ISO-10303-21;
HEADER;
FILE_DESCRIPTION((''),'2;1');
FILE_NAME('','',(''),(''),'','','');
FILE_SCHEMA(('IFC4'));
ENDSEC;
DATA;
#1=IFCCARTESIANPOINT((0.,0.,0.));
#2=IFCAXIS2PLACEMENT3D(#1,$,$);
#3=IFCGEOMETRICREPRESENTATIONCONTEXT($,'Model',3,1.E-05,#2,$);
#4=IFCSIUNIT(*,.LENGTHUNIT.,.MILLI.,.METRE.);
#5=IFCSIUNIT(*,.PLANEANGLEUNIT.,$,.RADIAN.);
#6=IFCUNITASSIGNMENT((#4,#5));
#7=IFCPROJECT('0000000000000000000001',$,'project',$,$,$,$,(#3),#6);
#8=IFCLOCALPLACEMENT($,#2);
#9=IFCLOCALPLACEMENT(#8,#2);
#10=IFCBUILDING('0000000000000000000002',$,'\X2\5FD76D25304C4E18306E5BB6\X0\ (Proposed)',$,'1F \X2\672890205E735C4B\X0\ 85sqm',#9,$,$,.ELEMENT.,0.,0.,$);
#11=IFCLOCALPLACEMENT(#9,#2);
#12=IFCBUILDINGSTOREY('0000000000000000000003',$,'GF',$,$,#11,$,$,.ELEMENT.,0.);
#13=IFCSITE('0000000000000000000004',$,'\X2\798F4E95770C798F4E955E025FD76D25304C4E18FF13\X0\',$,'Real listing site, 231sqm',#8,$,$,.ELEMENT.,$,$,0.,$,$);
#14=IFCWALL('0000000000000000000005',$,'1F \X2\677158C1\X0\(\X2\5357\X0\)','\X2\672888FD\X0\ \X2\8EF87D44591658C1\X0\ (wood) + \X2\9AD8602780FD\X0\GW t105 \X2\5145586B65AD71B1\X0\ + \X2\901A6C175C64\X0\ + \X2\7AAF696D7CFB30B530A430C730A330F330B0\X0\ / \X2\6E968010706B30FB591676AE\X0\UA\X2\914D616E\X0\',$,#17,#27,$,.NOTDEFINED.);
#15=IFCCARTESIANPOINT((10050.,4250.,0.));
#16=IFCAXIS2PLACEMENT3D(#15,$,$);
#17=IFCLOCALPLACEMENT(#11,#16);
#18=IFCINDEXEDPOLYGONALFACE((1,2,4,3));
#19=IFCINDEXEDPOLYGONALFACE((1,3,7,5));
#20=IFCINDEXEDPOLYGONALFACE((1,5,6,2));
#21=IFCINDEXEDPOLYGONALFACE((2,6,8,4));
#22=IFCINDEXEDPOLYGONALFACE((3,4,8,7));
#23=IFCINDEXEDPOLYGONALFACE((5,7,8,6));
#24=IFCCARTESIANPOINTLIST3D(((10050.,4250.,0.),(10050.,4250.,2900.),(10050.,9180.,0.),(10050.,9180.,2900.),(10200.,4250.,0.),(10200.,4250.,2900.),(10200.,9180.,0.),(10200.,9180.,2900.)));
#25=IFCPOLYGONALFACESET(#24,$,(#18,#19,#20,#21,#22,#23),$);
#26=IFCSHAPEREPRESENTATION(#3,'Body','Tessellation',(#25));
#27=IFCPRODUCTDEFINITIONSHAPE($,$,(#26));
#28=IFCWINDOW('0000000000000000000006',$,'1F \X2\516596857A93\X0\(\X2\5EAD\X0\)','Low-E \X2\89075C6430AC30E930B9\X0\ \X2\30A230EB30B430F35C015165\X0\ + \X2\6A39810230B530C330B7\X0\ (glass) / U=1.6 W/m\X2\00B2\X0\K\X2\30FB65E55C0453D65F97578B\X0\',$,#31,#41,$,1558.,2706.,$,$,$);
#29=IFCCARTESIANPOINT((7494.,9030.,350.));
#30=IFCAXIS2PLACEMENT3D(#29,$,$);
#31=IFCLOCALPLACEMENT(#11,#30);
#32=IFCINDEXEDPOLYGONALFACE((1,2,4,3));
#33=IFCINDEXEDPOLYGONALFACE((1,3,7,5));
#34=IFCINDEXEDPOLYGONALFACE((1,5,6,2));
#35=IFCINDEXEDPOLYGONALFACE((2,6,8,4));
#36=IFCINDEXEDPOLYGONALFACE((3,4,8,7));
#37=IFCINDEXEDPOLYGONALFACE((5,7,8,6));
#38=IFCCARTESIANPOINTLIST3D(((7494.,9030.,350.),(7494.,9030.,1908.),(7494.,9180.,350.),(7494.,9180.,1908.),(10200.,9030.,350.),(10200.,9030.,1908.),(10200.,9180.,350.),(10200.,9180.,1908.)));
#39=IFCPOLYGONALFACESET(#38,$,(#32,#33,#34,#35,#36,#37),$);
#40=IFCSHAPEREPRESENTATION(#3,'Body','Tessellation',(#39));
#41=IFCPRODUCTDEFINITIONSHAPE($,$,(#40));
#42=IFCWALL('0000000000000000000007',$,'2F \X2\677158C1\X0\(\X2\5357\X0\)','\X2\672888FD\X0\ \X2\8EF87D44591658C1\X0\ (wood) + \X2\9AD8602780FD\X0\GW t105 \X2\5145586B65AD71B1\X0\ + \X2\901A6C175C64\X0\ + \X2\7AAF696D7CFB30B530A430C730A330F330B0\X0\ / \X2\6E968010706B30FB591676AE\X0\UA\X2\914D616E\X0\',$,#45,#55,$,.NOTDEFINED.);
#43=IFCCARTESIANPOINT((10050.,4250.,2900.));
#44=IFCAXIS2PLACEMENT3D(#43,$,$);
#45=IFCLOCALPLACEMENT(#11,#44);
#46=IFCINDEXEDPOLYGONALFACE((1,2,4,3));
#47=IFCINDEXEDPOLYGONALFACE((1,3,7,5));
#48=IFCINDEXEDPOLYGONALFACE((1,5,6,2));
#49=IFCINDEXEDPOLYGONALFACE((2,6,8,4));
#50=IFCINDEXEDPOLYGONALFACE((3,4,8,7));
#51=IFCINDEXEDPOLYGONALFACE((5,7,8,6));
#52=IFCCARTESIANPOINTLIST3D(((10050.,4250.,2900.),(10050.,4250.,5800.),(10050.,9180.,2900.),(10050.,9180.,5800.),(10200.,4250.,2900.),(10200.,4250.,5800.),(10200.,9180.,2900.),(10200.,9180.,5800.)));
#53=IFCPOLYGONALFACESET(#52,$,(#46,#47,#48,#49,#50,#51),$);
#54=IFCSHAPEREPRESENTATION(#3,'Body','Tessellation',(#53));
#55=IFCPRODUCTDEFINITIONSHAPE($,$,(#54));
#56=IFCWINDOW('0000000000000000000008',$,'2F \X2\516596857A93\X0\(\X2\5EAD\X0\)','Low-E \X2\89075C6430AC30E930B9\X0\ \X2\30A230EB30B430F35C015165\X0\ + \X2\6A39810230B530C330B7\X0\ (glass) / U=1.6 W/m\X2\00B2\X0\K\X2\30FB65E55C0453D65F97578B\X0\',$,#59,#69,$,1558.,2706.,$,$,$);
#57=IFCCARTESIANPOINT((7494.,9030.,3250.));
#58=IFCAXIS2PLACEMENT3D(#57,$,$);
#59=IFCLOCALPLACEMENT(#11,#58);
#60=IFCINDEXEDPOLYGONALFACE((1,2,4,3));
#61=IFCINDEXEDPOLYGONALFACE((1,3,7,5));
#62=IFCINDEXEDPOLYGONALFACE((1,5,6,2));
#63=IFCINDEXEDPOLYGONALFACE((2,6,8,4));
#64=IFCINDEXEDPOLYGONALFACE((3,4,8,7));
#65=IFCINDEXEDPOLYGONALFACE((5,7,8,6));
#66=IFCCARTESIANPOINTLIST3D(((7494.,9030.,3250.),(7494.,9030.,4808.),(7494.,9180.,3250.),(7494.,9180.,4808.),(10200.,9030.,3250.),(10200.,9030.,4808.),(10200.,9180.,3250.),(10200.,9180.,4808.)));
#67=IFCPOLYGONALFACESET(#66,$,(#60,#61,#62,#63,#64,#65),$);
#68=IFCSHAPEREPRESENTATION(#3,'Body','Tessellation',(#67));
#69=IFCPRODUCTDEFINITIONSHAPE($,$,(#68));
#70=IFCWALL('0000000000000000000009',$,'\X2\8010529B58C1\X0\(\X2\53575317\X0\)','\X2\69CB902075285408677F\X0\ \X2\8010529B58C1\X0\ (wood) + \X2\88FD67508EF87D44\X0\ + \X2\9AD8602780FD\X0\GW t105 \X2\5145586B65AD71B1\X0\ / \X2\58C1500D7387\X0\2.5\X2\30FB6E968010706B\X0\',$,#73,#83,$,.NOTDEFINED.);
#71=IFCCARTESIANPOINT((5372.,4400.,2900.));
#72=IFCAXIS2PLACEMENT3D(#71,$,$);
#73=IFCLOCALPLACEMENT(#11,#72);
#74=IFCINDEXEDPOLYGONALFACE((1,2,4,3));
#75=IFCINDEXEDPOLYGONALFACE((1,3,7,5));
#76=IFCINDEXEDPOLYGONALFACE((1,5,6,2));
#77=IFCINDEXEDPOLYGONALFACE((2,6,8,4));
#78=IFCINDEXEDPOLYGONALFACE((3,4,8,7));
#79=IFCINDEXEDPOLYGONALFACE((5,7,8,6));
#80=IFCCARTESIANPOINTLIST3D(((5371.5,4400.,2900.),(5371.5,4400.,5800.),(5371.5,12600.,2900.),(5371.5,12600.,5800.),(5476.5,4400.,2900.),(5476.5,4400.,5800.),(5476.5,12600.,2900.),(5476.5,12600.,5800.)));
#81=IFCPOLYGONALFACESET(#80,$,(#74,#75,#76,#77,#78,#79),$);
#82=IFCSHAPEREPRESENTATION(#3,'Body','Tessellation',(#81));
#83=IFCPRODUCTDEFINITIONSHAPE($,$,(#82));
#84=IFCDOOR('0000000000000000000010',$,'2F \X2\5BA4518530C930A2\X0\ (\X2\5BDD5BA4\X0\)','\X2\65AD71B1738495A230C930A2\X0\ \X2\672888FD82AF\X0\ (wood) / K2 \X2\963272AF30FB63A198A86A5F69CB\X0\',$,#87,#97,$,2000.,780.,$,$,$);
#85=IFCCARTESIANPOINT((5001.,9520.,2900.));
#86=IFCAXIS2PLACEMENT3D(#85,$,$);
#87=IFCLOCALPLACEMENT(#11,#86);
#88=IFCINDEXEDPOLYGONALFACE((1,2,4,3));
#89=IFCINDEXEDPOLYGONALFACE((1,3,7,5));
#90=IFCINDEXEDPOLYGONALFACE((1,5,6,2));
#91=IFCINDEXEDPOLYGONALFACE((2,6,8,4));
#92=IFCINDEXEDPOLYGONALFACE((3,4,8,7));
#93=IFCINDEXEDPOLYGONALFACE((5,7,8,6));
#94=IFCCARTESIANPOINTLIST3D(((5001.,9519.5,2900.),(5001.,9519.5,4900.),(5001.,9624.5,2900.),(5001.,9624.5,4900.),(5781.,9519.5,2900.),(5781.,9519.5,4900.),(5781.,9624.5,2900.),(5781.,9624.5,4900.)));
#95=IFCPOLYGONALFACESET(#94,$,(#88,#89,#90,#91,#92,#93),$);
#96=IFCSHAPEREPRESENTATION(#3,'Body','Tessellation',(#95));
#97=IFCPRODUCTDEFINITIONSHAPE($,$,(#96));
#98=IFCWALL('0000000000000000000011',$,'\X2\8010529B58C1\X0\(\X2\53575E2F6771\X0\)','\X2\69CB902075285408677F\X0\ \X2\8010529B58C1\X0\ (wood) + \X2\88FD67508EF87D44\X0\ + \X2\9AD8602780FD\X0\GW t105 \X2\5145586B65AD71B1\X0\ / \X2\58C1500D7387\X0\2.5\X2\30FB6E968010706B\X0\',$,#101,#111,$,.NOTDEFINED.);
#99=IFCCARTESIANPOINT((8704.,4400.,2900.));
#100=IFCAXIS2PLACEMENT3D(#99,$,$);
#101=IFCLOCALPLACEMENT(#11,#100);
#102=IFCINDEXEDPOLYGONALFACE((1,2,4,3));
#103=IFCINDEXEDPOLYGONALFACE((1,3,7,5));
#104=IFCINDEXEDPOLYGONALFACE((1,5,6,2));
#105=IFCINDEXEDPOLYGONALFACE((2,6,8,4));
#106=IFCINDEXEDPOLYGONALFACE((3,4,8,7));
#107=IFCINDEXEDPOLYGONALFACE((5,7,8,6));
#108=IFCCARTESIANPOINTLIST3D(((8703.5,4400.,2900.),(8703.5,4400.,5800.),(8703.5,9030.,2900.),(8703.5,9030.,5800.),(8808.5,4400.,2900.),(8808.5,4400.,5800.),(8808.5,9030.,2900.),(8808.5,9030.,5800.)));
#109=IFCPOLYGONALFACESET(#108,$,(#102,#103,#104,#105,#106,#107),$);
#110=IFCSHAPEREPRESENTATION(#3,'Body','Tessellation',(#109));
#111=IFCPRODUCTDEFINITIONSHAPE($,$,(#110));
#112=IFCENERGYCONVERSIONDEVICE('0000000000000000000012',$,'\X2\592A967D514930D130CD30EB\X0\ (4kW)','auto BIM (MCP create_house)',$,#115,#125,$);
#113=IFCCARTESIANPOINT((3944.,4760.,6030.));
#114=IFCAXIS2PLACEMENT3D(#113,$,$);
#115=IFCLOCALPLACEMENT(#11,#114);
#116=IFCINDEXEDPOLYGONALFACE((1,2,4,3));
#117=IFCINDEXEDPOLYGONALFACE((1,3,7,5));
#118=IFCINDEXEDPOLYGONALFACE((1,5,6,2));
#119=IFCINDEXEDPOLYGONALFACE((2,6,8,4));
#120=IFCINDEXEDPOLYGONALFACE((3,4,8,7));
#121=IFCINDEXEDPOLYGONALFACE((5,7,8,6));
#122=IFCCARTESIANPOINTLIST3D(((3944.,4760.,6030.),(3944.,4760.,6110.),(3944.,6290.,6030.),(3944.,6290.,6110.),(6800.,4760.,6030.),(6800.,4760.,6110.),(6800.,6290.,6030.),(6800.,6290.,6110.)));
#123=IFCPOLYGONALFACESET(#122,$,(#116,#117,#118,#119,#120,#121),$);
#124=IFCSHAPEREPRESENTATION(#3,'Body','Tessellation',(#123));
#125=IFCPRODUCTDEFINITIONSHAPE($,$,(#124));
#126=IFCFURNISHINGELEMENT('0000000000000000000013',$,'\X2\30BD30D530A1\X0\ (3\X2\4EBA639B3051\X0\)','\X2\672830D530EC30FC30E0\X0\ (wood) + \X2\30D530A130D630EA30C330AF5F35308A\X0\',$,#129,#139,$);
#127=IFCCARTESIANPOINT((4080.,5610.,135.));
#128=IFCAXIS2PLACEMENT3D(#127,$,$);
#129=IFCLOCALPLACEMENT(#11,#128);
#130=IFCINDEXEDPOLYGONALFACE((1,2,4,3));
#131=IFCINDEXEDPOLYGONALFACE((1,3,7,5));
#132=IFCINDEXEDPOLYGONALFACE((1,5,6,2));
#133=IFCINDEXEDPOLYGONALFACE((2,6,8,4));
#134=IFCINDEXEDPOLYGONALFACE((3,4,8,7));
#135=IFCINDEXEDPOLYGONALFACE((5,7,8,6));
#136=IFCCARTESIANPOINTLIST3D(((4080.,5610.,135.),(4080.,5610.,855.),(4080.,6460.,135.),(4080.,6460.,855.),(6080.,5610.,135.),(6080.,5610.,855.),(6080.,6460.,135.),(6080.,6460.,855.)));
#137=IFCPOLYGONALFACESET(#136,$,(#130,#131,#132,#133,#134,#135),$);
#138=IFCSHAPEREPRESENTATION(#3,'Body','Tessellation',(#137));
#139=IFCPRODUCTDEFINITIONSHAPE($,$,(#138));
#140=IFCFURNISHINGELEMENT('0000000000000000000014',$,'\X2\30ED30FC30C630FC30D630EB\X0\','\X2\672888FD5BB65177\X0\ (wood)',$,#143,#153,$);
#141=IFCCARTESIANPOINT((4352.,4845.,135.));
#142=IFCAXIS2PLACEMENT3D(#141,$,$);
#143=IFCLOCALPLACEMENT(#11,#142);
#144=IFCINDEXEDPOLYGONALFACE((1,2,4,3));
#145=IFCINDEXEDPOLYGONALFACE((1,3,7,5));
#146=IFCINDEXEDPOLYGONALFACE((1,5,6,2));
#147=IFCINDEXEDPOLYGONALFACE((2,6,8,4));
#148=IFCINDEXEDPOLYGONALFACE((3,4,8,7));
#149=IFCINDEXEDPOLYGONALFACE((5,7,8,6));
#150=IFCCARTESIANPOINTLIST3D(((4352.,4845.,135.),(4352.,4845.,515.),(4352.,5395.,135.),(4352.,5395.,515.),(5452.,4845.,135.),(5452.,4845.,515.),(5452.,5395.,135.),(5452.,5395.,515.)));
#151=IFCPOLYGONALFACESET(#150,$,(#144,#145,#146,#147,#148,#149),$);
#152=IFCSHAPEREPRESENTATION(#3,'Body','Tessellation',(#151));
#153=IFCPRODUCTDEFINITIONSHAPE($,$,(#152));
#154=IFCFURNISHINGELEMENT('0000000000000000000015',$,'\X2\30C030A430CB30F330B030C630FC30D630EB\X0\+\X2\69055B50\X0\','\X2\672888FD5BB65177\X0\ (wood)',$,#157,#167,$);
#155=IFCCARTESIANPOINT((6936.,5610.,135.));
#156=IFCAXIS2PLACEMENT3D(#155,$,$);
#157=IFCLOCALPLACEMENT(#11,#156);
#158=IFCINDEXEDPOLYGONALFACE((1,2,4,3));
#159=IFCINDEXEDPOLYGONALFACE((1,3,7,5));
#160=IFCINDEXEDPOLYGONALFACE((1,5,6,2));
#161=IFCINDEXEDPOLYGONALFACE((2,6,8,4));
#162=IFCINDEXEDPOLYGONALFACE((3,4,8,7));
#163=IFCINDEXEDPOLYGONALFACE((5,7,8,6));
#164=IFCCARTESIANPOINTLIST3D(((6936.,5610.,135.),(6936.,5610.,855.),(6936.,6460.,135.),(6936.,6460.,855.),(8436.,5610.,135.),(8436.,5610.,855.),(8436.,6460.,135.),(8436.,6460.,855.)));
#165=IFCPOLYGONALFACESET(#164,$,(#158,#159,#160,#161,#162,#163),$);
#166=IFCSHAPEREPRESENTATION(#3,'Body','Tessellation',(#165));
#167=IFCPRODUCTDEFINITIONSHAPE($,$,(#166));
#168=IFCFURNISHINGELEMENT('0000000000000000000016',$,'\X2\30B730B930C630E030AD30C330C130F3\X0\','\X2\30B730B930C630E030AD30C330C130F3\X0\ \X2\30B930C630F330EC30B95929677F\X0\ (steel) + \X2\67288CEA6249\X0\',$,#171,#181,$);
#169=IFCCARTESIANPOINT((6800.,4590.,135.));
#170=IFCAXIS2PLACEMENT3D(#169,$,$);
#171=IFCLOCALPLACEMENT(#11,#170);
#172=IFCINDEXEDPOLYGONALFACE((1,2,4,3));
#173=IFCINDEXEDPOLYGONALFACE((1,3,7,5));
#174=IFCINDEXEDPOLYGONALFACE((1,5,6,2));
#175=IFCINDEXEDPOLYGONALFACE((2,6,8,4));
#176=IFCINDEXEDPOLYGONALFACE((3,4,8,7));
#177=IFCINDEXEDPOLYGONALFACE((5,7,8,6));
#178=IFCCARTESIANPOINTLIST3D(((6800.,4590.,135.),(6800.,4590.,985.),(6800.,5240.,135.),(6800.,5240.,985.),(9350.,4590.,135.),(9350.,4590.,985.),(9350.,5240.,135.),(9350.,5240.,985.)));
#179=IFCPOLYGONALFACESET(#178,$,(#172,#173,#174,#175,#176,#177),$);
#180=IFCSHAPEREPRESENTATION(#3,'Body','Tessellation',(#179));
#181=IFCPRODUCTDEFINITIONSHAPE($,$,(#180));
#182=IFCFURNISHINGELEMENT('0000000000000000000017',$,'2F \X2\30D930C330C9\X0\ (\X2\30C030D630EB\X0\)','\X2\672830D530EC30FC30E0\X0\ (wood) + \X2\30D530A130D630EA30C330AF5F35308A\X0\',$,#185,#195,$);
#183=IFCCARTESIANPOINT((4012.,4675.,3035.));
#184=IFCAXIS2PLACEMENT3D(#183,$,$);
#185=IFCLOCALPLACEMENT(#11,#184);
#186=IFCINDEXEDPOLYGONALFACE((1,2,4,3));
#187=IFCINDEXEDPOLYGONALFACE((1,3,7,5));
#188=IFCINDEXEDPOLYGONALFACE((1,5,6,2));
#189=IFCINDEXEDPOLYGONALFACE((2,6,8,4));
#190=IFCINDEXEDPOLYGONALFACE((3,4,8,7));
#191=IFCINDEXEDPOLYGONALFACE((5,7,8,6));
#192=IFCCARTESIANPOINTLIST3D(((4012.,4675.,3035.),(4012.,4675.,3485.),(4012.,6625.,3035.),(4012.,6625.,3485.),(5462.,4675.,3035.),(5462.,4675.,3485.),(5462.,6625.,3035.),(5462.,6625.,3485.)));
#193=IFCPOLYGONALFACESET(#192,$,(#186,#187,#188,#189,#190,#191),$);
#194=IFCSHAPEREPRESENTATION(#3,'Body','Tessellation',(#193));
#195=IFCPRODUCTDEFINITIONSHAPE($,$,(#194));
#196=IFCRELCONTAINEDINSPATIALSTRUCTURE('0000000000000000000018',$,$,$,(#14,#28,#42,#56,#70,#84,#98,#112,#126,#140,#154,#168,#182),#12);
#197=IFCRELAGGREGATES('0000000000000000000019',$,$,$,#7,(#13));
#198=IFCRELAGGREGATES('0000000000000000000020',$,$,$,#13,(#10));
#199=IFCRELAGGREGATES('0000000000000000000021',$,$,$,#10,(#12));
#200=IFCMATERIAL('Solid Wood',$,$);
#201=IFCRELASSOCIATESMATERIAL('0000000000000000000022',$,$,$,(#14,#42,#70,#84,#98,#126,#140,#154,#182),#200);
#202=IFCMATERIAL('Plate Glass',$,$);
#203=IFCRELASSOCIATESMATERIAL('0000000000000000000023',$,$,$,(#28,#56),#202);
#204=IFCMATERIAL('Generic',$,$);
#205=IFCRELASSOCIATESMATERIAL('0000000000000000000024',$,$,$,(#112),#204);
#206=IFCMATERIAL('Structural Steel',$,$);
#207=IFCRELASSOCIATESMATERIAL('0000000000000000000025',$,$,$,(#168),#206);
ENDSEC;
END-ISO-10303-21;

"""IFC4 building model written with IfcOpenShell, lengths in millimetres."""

from ifc_helpers import new_model, si_unit, frame, frame_2d, origin, place, context, project, spatial, rectangle, extrude, material, element, fill, save


model = new_model("IFC4")

# Units and contexts
model_context = context("Model", 3, precision=1e-05, world=origin())
ifc_project = project(units=[si_unit("LENGTHUNIT", "METRE", prefix="MILLI"), si_unit("PLANEANGLEUNIT", "RADIAN")], contexts=[model_context])

# Site, building, storey
site_placement = place(None, origin())
site = spatial("IfcSite", under=ifc_project, at=site_placement, Name="福井県福井市志津が丘３", ObjectType="Real listing site, 231sqm", CompositionType="ELEMENT", RefElevation=0.0)
building_placement = place(site_placement, origin())
building = spatial("IfcBuilding", under=site, at=building_placement, Name="志津が丘の家 (Proposed)", ObjectType="1F 木造平屋 85sqm", CompositionType="ELEMENT", ElevationOfRefHeight=0.0, ElevationOfTerrain=0.0)
storey_placement = place(building_placement, origin())
storey = spatial("IfcBuildingStorey", under=building, at=storey_placement, Name="GF", CompositionType="ELEMENT", Elevation=0.0)

# Wall, opening, window
ifc_material_1 = material(Name="Solid Wood")
wall_1_placement = place(storey_placement, frame((10050.0, 4250.0, 0.0)))
wall_1 = element("IfcWall", 1, at=wall_1_placement, inside=storey, material=ifc_material_1, Name="1F 東壁(南)", Description="木製 軸組外壁 (wood) + 高性能GW t105 充填断熱 + 通気層 + 窯業系サイディング / 準耐火・外皮UA配慮", PredefinedType="NOTDEFINED", context=model_context, shape_type="SweptSolid", body=[
    extrude(rectangle(XDim=150.0, YDim=4930.0, at=frame_2d((75.0, 2465.0))), frame((10050.0, 4250.0, 0.0)), (0.0, 0.0, 1.0), 2900.0),
])
opening_1_placement = place(storey_placement, frame((7494.0, 9030.0, 350.0)))
opening_1 = element("IfcOpeningElement", 2, at=opening_1_placement, cuts=wall_1, PredefinedType="NOTDEFINED", context=model_context, shape_type="SweptSolid", body=[
    extrude(rectangle(XDim=2706.0, YDim=150.0, at=frame_2d((1353.0, 75.0))), frame((7494.0, 9030.0, 350.0)), (0.0, 0.0, 1.0), 1558.0),
])
ifc_material_2 = material(Name="Plate Glass")
window_1_placement = place(storey_placement, frame((7494.0, 9030.0, 350.0)))
window_1 = element("IfcWindow", 3, at=window_1_placement, inside=storey, material=ifc_material_2, Name="1F 入隅窓(庭)", Description="Low-E 複層ガラス アルゴン封入 + 樹脂サッシ (glass) / U=1.6 W/m²K・日射取得型", OverallHeight=1558.0, OverallWidth=2706.0, context=model_context, shape_type="SweptSolid", body=[
    extrude(rectangle(XDim=2706.0, YDim=150.0, at=frame_2d((1353.0, 75.0))), frame((7494.0, 9030.0, 350.0)), (0.0, 0.0, 1.0), 1558.0),
])
fill(opening_1, window_1)

# Wall, opening, window
wall_2_placement = place(storey_placement, frame((10050.0, 4250.0, 2900.0)))
wall_2 = element("IfcWall", 4, at=wall_2_placement, inside=storey, material=ifc_material_1, Name="2F 東壁(南)", Description="木製 軸組外壁 (wood) + 高性能GW t105 充填断熱 + 通気層 + 窯業系サイディング / 準耐火・外皮UA配慮", PredefinedType="NOTDEFINED", context=model_context, shape_type="SweptSolid", body=[
    extrude(rectangle(XDim=150.0, YDim=4930.0, at=frame_2d((75.0, 2465.0))), frame((10050.0, 4250.0, 2900.0)), (0.0, 0.0, 1.0), 2900.0),
])
opening_2_placement = place(storey_placement, frame((7494.0, 9030.0, 3250.0)))
opening_2 = element("IfcOpeningElement", 5, at=opening_2_placement, cuts=wall_2, PredefinedType="NOTDEFINED", context=model_context, shape_type="SweptSolid", body=[
    extrude(rectangle(XDim=2706.0, YDim=150.0, at=frame_2d((1353.0, 75.0))), frame((7494.0, 9030.0, 3250.0)), (0.0, 0.0, 1.0), 1558.0),
])
window_2_placement = place(storey_placement, frame((7494.0, 9030.0, 3250.0)))
window_2 = element("IfcWindow", 6, at=window_2_placement, inside=storey, material=ifc_material_2, Name="2F 入隅窓(庭)", Description="Low-E 複層ガラス アルゴン封入 + 樹脂サッシ (glass) / U=1.6 W/m²K・日射取得型", OverallHeight=1558.0, OverallWidth=2706.0, context=model_context, shape_type="SweptSolid", body=[
    extrude(rectangle(XDim=2706.0, YDim=150.0, at=frame_2d((1353.0, 75.0))), frame((7494.0, 9030.0, 3250.0)), (0.0, 0.0, 1.0), 1558.0),
])
fill(opening_2, window_2)

# Wall, opening, door
wall_3_placement = place(storey_placement, frame((5372.0, 4400.0, 2900.0)))
wall_3 = element("IfcWall", 7, at=wall_3_placement, inside=storey, material=ifc_material_1, Name="耐力壁(南北)", Description="構造用合板 耐力壁 (wood) + 製材軸組 + 高性能GW t105 充填断熱 / 壁倍率2.5・準耐火", PredefinedType="NOTDEFINED", context=model_context, shape_type="SweptSolid", body=[
    extrude(rectangle(XDim=105.0, YDim=8200.0, at=frame_2d((52.0, 4100.0))), frame((5372.0, 4400.0, 2900.0)), (0.0, 0.0, 1.0), 2900.0),
])
opening_3_placement = place(storey_placement, frame((5001.0, 9520.0, 2900.0)))
opening_3 = element("IfcOpeningElement", 8, at=opening_3_placement, cuts=wall_3, PredefinedType="NOTDEFINED", context=model_context, shape_type="SweptSolid", body=[
    extrude(rectangle(XDim=780.0, YDim=105.0, at=frame_2d((390.0, 52.0))), frame((5001.0, 9520.0, 2900.0)), (0.0, 0.0, 1.0), 2000.0),
])
door_1_placement = place(storey_placement, frame((5001.0, 9520.0, 2900.0)))
door_1 = element("IfcDoor", 9, at=door_1_placement, inside=storey, material=ifc_material_1, Name="2F 室内ドア (寝室)", Description="断熱玄関ドア 木製芯 (wood) / K2 防犯・採風機構", OverallHeight=2000.0, OverallWidth=780.0, context=model_context, shape_type="SweptSolid", body=[
    extrude(rectangle(XDim=780.0, YDim=105.0, at=frame_2d((390.0, 52.0))), frame((5001.0, 9520.0, 2900.0)), (0.0, 0.0, 1.0), 2000.0),
])
fill(opening_3, door_1)

# Wall
wall_4_placement = place(storey_placement, frame((8704.0, 4400.0, 2900.0)))
element("IfcWall", 10, at=wall_4_placement, inside=storey, material=ifc_material_1, Name="耐力壁(南帯東)", Description="構造用合板 耐力壁 (wood) + 製材軸組 + 高性能GW t105 充填断熱 / 壁倍率2.5・準耐火", PredefinedType="NOTDEFINED", context=model_context, shape_type="SweptSolid", body=[
    extrude(rectangle(XDim=105.0, YDim=4630.0, at=frame_2d((52.0, 2315.0))), frame((8704.0, 4400.0, 2900.0)), (0.0, 0.0, 1.0), 2900.0),
])

# Energy conversion device
ifc_material_3 = material(Name="Generic")
energy_conversion_device_placement = place(storey_placement, frame((3944.0, 4760.0, 6030.0)))
element("IfcEnergyConversionDevice", 11, at=energy_conversion_device_placement, inside=storey, material=ifc_material_3, Name="太陽光パネル (4kW)", Description="auto BIM (MCP create_house)", context=model_context, shape_type="SweptSolid", body=[
    extrude(rectangle(XDim=2856.0, YDim=1530.0, at=frame_2d((1428.0, 765.0))), frame((3944.0, 4760.0, 6030.0)), (0.0, 0.0, 1.0), 80.0),
])

# Furnishing elements
furnishing_1_placement = place(storey_placement, frame((4080.0, 5610.0, 135.0)))
element("IfcFurnishingElement", 12, at=furnishing_1_placement, inside=storey, material=ifc_material_1, Name="ソファ (3人掛け)", Description="木フレーム (wood) + ファブリック張り", context=model_context, shape_type="SweptSolid", body=[
    extrude(rectangle(XDim=2000.0, YDim=850.0, at=frame_2d((1000.0, 425.0))), frame((4080.0, 5610.0, 135.0)), (0.0, 0.0, 1.0), 720.0),
])
furnishing_2_placement = place(storey_placement, frame((4352.0, 4845.0, 135.0)))
element("IfcFurnishingElement", 13, at=furnishing_2_placement, inside=storey, material=ifc_material_1, Name="ローテーブル", Description="木製家具 (wood)", context=model_context, shape_type="SweptSolid", body=[
    extrude(rectangle(XDim=1100.0, YDim=550.0, at=frame_2d((550.0, 275.0))), frame((4352.0, 4845.0, 135.0)), (0.0, 0.0, 1.0), 380.0),
])
furnishing_3_placement = place(storey_placement, frame((6936.0, 5610.0, 135.0)))
element("IfcFurnishingElement", 14, at=furnishing_3_placement, inside=storey, material=ifc_material_1, Name="ダイニングテーブル+椅子", Description="木製家具 (wood)", context=model_context, shape_type="SweptSolid", body=[
    extrude(rectangle(XDim=1500.0, YDim=850.0, at=frame_2d((750.0, 425.0))), frame((6936.0, 5610.0, 135.0)), (0.0, 0.0, 1.0), 720.0),
])
ifc_material_4 = material(Name="Structural Steel")
furnishing_4_placement = place(storey_placement, frame((6800.0, 4590.0, 135.0)))
element("IfcFurnishingElement", 15, at=furnishing_4_placement, inside=storey, material=ifc_material_4, Name="システムキッチン", Description="システムキッチン ステンレス天板 (steel) + 木質扉", context=model_context, shape_type="SweptSolid", body=[
    extrude(rectangle(XDim=2550.0, YDim=650.0, at=frame_2d((1275.0, 325.0))), frame((6800.0, 4590.0, 135.0)), (0.0, 0.0, 1.0), 850.0),
])
furnishing_5_placement = place(storey_placement, frame((4012.0, 4675.0, 3035.0)))
element("IfcFurnishingElement", 16, at=furnishing_5_placement, inside=storey, material=ifc_material_1, Name="2F ベッド (ダブル)", Description="木フレーム (wood) + ファブリック張り", context=model_context, shape_type="SweptSolid", body=[
    extrude(rectangle(XDim=1450.0, YDim=1950.0, at=frame_2d((725.0, 975.0))), frame((4012.0, 4675.0, 3035.0)), (0.0, 0.0, 1.0), 450.0),
])

save(model, "model.ifc")
